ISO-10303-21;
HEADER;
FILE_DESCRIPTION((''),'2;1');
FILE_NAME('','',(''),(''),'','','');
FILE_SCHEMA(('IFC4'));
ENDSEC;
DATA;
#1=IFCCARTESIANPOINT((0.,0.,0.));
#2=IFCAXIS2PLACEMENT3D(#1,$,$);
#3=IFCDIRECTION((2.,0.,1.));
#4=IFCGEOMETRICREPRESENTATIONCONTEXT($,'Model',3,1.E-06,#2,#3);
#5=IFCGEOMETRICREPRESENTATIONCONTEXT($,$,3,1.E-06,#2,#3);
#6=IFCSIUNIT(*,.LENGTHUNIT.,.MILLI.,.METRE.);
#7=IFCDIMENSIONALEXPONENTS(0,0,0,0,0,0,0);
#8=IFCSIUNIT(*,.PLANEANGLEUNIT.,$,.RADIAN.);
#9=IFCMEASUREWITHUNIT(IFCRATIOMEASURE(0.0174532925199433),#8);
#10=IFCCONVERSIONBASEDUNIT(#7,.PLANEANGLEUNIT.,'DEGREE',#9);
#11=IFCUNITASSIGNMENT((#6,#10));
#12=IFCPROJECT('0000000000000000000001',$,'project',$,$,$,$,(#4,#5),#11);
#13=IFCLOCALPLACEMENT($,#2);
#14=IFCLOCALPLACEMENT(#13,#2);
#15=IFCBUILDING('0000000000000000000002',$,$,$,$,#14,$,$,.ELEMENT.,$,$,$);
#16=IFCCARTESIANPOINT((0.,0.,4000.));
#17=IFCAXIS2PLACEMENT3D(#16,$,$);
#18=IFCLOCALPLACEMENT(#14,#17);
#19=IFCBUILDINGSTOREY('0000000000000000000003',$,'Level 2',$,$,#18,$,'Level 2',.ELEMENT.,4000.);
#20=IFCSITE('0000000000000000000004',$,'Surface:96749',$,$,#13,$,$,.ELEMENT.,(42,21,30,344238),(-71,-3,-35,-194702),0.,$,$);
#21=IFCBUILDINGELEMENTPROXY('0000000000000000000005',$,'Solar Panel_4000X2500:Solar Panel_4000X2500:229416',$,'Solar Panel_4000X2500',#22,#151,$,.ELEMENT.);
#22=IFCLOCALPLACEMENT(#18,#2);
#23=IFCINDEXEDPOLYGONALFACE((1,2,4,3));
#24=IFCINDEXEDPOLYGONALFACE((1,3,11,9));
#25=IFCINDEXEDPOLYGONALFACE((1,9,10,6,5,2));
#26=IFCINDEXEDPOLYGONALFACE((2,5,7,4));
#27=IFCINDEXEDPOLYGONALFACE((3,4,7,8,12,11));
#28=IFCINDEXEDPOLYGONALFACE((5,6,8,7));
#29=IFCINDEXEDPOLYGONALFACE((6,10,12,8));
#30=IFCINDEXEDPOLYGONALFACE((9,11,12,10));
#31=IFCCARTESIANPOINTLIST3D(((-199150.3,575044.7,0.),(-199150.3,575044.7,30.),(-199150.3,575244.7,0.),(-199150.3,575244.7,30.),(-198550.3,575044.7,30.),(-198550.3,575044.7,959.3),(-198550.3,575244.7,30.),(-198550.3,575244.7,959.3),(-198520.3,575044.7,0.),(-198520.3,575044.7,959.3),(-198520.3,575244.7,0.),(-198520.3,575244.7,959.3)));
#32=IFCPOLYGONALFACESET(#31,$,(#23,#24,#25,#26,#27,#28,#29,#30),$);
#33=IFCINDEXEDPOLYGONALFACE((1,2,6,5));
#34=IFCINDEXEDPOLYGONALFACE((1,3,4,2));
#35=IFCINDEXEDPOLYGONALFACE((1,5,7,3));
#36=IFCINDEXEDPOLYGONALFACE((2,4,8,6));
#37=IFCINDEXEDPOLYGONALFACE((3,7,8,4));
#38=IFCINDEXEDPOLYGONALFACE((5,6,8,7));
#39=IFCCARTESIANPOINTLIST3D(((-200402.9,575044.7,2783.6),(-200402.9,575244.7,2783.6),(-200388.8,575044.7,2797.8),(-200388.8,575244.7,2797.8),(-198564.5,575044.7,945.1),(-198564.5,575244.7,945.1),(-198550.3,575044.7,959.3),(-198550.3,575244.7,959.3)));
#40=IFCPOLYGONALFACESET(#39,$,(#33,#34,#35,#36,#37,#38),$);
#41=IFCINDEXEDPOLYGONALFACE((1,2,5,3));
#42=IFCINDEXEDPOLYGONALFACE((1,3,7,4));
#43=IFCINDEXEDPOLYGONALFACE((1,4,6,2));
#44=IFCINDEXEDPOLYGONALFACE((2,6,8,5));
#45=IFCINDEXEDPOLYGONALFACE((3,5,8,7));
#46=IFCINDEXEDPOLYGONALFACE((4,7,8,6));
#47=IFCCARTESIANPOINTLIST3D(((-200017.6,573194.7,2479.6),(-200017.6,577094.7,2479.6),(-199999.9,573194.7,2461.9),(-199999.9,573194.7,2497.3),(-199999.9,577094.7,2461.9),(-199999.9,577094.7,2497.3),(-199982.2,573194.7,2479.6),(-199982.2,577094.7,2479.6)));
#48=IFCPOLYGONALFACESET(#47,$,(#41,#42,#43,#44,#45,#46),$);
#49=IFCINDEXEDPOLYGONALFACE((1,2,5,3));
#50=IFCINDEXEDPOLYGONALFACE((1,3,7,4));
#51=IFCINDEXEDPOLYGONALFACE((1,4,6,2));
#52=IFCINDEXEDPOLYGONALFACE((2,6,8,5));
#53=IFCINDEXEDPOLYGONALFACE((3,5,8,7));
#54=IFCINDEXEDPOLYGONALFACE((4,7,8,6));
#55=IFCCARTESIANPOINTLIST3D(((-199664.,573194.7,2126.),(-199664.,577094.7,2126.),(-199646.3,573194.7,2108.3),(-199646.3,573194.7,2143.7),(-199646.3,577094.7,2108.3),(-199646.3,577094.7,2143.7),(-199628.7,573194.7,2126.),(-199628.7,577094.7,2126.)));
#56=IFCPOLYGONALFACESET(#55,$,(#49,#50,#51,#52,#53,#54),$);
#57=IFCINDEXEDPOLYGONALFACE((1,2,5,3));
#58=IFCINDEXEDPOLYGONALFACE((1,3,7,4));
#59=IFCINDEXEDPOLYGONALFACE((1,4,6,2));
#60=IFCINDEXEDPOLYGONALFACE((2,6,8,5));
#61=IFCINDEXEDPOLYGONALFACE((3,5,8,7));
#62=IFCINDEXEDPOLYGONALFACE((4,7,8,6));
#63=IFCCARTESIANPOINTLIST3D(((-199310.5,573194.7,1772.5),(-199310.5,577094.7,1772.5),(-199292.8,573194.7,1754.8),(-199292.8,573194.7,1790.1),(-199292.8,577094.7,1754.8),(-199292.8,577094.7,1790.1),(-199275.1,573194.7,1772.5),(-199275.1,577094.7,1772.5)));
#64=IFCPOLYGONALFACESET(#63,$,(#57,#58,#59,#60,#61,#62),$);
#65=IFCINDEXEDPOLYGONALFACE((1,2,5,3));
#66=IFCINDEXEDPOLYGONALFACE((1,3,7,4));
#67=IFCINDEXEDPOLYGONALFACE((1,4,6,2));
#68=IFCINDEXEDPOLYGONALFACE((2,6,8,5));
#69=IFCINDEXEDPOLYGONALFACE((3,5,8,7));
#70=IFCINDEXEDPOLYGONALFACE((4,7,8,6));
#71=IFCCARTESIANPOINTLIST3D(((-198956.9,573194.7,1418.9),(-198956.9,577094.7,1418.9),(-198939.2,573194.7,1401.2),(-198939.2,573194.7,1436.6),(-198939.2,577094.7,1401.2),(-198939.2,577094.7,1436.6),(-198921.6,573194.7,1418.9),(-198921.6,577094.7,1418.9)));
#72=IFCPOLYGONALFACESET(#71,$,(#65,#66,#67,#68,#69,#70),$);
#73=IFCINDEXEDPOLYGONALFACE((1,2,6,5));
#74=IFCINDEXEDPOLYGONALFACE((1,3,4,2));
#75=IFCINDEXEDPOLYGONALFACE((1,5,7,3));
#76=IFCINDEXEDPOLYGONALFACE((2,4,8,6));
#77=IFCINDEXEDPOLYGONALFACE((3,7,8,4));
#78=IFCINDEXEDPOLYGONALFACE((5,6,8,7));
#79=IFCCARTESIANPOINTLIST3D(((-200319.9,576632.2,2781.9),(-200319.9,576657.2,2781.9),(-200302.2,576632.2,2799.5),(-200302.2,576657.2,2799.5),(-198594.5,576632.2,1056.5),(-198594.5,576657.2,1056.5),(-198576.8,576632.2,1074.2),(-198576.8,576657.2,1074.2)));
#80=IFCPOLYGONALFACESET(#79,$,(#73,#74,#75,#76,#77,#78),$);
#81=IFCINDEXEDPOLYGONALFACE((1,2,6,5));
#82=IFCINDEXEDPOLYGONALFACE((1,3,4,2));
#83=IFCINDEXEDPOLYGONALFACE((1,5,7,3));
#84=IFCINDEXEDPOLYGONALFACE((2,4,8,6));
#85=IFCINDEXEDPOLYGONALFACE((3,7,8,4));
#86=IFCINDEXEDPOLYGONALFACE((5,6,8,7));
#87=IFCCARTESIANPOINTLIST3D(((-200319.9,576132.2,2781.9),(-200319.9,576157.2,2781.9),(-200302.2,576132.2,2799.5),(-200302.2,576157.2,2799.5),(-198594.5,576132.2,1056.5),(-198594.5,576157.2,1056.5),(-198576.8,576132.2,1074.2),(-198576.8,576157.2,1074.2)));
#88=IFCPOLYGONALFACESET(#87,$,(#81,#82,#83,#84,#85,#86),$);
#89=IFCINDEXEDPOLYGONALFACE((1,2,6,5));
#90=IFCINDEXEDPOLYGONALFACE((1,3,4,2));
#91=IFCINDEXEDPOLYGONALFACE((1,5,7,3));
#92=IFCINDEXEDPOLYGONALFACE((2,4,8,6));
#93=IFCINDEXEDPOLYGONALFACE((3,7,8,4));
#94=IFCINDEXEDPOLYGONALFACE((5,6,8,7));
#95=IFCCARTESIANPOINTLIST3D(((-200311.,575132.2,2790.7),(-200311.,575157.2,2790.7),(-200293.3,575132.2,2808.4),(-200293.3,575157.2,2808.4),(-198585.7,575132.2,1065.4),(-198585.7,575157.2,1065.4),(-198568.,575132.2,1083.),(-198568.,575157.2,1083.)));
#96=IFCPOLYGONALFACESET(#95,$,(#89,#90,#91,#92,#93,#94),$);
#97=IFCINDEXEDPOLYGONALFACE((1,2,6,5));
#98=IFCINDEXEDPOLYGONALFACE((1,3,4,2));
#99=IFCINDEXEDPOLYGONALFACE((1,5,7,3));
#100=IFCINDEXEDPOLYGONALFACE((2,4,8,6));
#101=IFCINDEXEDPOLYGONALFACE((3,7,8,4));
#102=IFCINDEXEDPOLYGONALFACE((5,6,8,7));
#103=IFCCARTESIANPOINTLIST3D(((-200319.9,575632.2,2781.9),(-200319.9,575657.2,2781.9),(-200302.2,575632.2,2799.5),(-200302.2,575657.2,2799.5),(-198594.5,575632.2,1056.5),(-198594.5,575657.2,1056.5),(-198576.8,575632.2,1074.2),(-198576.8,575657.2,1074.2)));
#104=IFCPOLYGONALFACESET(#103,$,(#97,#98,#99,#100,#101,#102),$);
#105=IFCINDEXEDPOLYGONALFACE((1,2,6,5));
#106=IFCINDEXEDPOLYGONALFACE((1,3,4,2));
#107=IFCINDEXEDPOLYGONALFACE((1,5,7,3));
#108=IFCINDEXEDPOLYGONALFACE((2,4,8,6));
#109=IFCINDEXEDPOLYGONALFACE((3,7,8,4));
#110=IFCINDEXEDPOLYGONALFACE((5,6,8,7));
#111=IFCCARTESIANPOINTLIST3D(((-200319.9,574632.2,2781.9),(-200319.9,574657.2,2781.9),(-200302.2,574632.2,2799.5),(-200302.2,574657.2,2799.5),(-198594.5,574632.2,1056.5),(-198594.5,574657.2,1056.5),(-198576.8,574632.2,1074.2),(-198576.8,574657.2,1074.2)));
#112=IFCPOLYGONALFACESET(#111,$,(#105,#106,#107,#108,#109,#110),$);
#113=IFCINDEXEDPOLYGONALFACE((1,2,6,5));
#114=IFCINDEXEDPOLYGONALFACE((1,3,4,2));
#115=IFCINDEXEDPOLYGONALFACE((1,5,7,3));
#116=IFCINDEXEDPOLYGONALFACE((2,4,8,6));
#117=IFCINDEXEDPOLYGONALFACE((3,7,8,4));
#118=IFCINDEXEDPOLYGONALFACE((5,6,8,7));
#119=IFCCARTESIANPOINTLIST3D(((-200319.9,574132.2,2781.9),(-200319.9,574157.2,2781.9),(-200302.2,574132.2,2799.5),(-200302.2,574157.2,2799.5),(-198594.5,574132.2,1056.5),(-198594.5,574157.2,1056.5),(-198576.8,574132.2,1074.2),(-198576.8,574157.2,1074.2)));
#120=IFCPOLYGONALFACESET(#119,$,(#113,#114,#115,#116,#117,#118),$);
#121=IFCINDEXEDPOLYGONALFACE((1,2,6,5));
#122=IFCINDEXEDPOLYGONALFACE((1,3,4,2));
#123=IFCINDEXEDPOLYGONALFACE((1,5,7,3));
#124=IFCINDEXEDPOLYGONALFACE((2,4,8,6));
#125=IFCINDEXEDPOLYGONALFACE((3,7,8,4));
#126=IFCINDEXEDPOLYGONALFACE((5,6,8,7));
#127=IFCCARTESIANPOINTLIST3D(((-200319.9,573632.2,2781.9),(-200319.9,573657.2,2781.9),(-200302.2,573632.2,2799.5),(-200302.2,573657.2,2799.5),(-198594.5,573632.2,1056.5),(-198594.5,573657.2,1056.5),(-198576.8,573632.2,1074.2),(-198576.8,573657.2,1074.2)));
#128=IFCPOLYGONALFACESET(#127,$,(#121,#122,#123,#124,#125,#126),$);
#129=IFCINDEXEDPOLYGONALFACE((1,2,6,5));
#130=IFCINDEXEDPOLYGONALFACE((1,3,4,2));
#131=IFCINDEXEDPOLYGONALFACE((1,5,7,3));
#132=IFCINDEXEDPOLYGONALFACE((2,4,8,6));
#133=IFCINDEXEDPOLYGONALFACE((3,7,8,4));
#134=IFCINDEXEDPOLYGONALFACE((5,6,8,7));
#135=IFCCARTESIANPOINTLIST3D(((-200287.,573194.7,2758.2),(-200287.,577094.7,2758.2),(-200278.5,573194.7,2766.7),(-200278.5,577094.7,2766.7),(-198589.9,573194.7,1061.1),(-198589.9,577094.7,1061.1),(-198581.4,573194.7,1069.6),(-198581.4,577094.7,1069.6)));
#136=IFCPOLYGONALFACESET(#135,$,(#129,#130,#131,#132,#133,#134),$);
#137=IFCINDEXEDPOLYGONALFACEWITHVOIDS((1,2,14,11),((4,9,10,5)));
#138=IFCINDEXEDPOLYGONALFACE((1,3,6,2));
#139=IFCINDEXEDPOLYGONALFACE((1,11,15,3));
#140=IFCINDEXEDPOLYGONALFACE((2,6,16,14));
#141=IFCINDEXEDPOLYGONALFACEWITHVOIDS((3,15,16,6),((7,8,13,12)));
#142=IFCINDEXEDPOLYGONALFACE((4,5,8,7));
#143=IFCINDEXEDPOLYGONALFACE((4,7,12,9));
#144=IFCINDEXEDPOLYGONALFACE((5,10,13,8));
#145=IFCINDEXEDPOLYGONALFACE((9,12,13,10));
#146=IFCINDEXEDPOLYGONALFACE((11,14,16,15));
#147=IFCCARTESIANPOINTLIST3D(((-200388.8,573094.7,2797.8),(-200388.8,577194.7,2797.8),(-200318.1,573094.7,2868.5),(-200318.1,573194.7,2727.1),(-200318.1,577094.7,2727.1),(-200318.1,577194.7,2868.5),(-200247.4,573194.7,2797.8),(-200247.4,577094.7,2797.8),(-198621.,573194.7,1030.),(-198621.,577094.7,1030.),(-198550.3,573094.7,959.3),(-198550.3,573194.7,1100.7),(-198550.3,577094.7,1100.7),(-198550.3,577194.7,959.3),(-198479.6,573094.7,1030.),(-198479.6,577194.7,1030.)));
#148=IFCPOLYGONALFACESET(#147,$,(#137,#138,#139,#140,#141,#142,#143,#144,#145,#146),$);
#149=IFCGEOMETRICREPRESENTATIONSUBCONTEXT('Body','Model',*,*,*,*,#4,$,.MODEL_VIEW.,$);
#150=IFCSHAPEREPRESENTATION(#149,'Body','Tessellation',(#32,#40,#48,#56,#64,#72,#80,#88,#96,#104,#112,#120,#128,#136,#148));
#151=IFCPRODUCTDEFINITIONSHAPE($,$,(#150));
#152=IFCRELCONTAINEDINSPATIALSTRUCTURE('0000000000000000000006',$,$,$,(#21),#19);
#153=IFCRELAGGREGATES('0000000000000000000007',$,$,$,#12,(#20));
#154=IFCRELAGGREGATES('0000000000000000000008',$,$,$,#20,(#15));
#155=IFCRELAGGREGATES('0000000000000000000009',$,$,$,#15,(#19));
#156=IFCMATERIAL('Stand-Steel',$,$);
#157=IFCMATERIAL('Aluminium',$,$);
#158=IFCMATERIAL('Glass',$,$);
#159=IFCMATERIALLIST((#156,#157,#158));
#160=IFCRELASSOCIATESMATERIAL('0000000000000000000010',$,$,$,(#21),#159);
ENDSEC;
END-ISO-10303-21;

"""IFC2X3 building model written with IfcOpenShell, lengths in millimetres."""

from ifc_helpers import new_model, entity, si_unit, converted_unit, direction, frame, frame_2d, origin, origin_2d_with_axis, place, context, subcontext, project, spatial, polyline, rectangle, outline, extrude, source, transform, mapped, material, material_list, element, save


model = new_model("IFC2X3")

# Units and contexts
model_context = context("Model", 3, precision=1e-06, world=origin(), true_north=direction((2.0, 0.0, 1.0)))
context_of_model = context(None, 3, precision=1e-06, world=origin(), true_north=direction((2.0, 0.0, 1.0)))
body_context = subcontext(model_context, "Body", "Model", "MODEL_VIEW")
ifc_project = project(units=[si_unit("LENGTHUNIT", "METRE", prefix="MILLI"), converted_unit("PLANEANGLEUNIT", "DEGREE", entity("IfcRatioMeasure", 0.0174532925199433), si_unit("PLANEANGLEUNIT", "RADIAN"), dimensions=[0, 0, 0, 0, 0, 0, 0])], contexts=[model_context, context_of_model])

# Site, building, storey
site_placement = place(None, origin())
site = spatial("IfcSite", under=ifc_project, at=site_placement, Name="Surface:96749", CompositionType="ELEMENT", RefLatitude=(42, 21, 30, 344238), RefLongitude=(-71, -3, -35, -194702), RefElevation=0.0)
building_placement = place(site_placement, origin())
building = spatial("IfcBuilding", under=site, at=building_placement, CompositionType="ELEMENT")
storey_placement = place(building_placement, frame((0.0, 0.0, 4000.0)))
storey = spatial("IfcBuildingStorey", under=building, at=storey_placement, Name="Level 2", LongName="Level 2", CompositionType="ELEMENT", Elevation=4000.0)

# Building element proxy
ifc_material_1 = material(Name="Stand-Steel")
ifc_material_2 = material(Name="Aluminium")
ifc_material_3 = material(Name="Glass")
shared_shape = source(origin(), body_context, "Body", "SweptSolid", [
    extrude(outline(polyline([(-629.5, -220.0), (329.8, -220.0), (329.8, 410.0), (299.8, 410.0), (299.8, -190.0), (-629.5, -190.0), (-629.5, -220.0)])), frame((-190.0, -100.0, 299.8), z_axis=(0.0, 1.0, 0.0), x_axis=(0.0, 0.0, -1.0)), (0.0, 0.0, 1.0), 200.0),
    extrude(rectangle(XDim=20.0, YDim=200.0, at=frame_2d((0.0, 0.0), x_axis=(0.0, 1.0))), frame((-7.1, 0.0, 922.2), z_axis=(-0.707107, 0.0, 0.707107), x_axis=(0.0, 1.0, 0.0)), (0.0, 0.0, 1.0), 2600.0),
    extrude(rectangle(XDim=25.0, YDim=25.0, at=frame_2d((0.0, 0.0), x_axis=(1.0, 0.0))), frame((-1449.6, -1950.0, 2449.6), z_axis=(0.0, 1.0, 0.0), x_axis=(-0.707107, 0.0, -0.707107)), (0.0, 0.0, 1.0), 3900.0),
    extrude(rectangle(XDim=25.0, YDim=25.0, at=origin_2d_with_axis()), frame((-1096.0, -1950.0, 2096.0), z_axis=(0.0, 1.0, 0.0), x_axis=(-0.707107, 0.0, -0.707107)), (0.0, 0.0, 1.0), 3900.0),
    extrude(rectangle(XDim=25.0, YDim=25.0, at=origin_2d_with_axis()), frame((-742.5, -1950.0, 1742.5), z_axis=(0.0, 1.0, 0.0), x_axis=(-0.707107, 0.0, -0.707107)), (0.0, 0.0, 1.0), 3900.0),
    extrude(rectangle(XDim=25.0, YDim=25.0, at=frame_2d((0.0, 0.0), x_axis=(1.0, 0.0))), frame((-388.9, -1950.0, 1388.9), z_axis=(0.0, 1.0, 0.0), x_axis=(-0.707107, 0.0, -0.707107)), (0.0, 0.0, 1.0), 3900.0),
    extrude(rectangle(XDim=25.0, YDim=25.0, at=frame_2d((0.0, 0.0), x_axis=(0.0, 1.0))), frame((-35.4, 1500.0, 1035.4), z_axis=(-0.707107, 0.0, 0.707107), x_axis=(0.0, 1.0, 0.0)), (0.0, 0.0, 1.0), 2440.0),
    extrude(rectangle(XDim=25.0, YDim=25.0, at=frame_2d((0.0, 0.0), x_axis=(0.0, 1.0))), frame((-35.4, 1000.0, 1035.4), z_axis=(-0.707107, 0.0, 0.707107), x_axis=(0.0, 1.0, 0.0)), (0.0, 0.0, 1.0), 2440.0),
    extrude(rectangle(XDim=25.0, YDim=25.0, at=frame_2d((0.0, 0.0), x_axis=(0.0, 1.0))), frame((-26.5, 0.0, 1044.2), z_axis=(-0.707107, 0.0, 0.707107), x_axis=(0.0, -1.0, 0.0)), (0.0, 0.0, 1.0), 2440.0),
    extrude(rectangle(XDim=25.0, YDim=25.0, at=frame_2d((0.0, 0.0), x_axis=(0.0, 1.0))), frame((-35.4, 500.0, 1035.4), z_axis=(-0.707107, 0.0, 0.707107), x_axis=(0.0, 1.0, 0.0)), (0.0, 0.0, 1.0), 2440.0),
    extrude(rectangle(XDim=25.0, YDim=25.0, at=frame_2d((0.0, 0.0), x_axis=(0.0, 1.0))), frame((-35.4, -500.0, 1035.4), z_axis=(-0.707107, 0.0, 0.707107), x_axis=(0.0, 1.0, 0.0)), (0.0, 0.0, 1.0), 2440.0),
    extrude(rectangle(XDim=25.0, YDim=25.0, at=frame_2d((0.0, 0.0), x_axis=(0.0, 1.0))), frame((-35.4, -1000.0, 1035.4), z_axis=(-0.707107, 0.0, 0.707107), x_axis=(0.0, 1.0, 0.0)), (0.0, 0.0, 1.0), 2440.0),
    extrude(rectangle(XDim=25.0, YDim=25.0, at=frame_2d((0.0, 0.0), x_axis=(0.0, 1.0))), frame((-35.4, -1500.0, 1035.4), z_axis=(-0.707107, 0.0, 0.707107), x_axis=(0.0, 1.0, 0.0)), (0.0, 0.0, 1.0), 2440.0),
    extrude(rectangle(XDim=2400.0, YDim=12.0, at=frame_2d((0.0, 0.0), x_axis=(1.0, 0.0))), frame((-883.9, -1950.0, 1883.9), z_axis=(0.0, 1.0, 0.0), x_axis=(0.707107, 0.0, -0.707107)), (0.0, 0.0, 1.0), 3900.0),
    extrude(outline(polyline([(-2050.0, -1300.0), (2050.0, -1300.0), (2050.0, 1300.0), (-2050.0, 1300.0), (-2050.0, -1300.0)]), holes=[polyline([(1950.0, -1200.0), (-1950.0, -1200.0), (-1950.0, 1200.0), (1950.0, 1200.0), (1950.0, -1200.0)])]), frame((-919.2, 0.0, 1848.5), z_axis=(0.707107, 0.0, 0.707107), x_axis=(0.0, 1.0, 0.0)), (0.0, 0.0, 1.0), 100.0),
])
ifc_material_list_1 = material_list([ifc_material_1, ifc_material_2, ifc_material_3])
proxy_1_placement = place(storey_placement, frame((-198550.3, 575144.7, 30.0)))
element("IfcBuildingElementProxy", 1, at=proxy_1_placement, inside=storey, material=ifc_material_list_1, Name="Solar Panel_4000X2500:Solar Panel_4000X2500:229416", ObjectType="Solar Panel_4000X2500", CompositionType="ELEMENT", context=body_context, shape_type="MappedRepresentation", body=[
    mapped(shared_shape, transform((0.0, 0.0, 0.0), scale=1.0)),
])

save(model, "model.ifc")
